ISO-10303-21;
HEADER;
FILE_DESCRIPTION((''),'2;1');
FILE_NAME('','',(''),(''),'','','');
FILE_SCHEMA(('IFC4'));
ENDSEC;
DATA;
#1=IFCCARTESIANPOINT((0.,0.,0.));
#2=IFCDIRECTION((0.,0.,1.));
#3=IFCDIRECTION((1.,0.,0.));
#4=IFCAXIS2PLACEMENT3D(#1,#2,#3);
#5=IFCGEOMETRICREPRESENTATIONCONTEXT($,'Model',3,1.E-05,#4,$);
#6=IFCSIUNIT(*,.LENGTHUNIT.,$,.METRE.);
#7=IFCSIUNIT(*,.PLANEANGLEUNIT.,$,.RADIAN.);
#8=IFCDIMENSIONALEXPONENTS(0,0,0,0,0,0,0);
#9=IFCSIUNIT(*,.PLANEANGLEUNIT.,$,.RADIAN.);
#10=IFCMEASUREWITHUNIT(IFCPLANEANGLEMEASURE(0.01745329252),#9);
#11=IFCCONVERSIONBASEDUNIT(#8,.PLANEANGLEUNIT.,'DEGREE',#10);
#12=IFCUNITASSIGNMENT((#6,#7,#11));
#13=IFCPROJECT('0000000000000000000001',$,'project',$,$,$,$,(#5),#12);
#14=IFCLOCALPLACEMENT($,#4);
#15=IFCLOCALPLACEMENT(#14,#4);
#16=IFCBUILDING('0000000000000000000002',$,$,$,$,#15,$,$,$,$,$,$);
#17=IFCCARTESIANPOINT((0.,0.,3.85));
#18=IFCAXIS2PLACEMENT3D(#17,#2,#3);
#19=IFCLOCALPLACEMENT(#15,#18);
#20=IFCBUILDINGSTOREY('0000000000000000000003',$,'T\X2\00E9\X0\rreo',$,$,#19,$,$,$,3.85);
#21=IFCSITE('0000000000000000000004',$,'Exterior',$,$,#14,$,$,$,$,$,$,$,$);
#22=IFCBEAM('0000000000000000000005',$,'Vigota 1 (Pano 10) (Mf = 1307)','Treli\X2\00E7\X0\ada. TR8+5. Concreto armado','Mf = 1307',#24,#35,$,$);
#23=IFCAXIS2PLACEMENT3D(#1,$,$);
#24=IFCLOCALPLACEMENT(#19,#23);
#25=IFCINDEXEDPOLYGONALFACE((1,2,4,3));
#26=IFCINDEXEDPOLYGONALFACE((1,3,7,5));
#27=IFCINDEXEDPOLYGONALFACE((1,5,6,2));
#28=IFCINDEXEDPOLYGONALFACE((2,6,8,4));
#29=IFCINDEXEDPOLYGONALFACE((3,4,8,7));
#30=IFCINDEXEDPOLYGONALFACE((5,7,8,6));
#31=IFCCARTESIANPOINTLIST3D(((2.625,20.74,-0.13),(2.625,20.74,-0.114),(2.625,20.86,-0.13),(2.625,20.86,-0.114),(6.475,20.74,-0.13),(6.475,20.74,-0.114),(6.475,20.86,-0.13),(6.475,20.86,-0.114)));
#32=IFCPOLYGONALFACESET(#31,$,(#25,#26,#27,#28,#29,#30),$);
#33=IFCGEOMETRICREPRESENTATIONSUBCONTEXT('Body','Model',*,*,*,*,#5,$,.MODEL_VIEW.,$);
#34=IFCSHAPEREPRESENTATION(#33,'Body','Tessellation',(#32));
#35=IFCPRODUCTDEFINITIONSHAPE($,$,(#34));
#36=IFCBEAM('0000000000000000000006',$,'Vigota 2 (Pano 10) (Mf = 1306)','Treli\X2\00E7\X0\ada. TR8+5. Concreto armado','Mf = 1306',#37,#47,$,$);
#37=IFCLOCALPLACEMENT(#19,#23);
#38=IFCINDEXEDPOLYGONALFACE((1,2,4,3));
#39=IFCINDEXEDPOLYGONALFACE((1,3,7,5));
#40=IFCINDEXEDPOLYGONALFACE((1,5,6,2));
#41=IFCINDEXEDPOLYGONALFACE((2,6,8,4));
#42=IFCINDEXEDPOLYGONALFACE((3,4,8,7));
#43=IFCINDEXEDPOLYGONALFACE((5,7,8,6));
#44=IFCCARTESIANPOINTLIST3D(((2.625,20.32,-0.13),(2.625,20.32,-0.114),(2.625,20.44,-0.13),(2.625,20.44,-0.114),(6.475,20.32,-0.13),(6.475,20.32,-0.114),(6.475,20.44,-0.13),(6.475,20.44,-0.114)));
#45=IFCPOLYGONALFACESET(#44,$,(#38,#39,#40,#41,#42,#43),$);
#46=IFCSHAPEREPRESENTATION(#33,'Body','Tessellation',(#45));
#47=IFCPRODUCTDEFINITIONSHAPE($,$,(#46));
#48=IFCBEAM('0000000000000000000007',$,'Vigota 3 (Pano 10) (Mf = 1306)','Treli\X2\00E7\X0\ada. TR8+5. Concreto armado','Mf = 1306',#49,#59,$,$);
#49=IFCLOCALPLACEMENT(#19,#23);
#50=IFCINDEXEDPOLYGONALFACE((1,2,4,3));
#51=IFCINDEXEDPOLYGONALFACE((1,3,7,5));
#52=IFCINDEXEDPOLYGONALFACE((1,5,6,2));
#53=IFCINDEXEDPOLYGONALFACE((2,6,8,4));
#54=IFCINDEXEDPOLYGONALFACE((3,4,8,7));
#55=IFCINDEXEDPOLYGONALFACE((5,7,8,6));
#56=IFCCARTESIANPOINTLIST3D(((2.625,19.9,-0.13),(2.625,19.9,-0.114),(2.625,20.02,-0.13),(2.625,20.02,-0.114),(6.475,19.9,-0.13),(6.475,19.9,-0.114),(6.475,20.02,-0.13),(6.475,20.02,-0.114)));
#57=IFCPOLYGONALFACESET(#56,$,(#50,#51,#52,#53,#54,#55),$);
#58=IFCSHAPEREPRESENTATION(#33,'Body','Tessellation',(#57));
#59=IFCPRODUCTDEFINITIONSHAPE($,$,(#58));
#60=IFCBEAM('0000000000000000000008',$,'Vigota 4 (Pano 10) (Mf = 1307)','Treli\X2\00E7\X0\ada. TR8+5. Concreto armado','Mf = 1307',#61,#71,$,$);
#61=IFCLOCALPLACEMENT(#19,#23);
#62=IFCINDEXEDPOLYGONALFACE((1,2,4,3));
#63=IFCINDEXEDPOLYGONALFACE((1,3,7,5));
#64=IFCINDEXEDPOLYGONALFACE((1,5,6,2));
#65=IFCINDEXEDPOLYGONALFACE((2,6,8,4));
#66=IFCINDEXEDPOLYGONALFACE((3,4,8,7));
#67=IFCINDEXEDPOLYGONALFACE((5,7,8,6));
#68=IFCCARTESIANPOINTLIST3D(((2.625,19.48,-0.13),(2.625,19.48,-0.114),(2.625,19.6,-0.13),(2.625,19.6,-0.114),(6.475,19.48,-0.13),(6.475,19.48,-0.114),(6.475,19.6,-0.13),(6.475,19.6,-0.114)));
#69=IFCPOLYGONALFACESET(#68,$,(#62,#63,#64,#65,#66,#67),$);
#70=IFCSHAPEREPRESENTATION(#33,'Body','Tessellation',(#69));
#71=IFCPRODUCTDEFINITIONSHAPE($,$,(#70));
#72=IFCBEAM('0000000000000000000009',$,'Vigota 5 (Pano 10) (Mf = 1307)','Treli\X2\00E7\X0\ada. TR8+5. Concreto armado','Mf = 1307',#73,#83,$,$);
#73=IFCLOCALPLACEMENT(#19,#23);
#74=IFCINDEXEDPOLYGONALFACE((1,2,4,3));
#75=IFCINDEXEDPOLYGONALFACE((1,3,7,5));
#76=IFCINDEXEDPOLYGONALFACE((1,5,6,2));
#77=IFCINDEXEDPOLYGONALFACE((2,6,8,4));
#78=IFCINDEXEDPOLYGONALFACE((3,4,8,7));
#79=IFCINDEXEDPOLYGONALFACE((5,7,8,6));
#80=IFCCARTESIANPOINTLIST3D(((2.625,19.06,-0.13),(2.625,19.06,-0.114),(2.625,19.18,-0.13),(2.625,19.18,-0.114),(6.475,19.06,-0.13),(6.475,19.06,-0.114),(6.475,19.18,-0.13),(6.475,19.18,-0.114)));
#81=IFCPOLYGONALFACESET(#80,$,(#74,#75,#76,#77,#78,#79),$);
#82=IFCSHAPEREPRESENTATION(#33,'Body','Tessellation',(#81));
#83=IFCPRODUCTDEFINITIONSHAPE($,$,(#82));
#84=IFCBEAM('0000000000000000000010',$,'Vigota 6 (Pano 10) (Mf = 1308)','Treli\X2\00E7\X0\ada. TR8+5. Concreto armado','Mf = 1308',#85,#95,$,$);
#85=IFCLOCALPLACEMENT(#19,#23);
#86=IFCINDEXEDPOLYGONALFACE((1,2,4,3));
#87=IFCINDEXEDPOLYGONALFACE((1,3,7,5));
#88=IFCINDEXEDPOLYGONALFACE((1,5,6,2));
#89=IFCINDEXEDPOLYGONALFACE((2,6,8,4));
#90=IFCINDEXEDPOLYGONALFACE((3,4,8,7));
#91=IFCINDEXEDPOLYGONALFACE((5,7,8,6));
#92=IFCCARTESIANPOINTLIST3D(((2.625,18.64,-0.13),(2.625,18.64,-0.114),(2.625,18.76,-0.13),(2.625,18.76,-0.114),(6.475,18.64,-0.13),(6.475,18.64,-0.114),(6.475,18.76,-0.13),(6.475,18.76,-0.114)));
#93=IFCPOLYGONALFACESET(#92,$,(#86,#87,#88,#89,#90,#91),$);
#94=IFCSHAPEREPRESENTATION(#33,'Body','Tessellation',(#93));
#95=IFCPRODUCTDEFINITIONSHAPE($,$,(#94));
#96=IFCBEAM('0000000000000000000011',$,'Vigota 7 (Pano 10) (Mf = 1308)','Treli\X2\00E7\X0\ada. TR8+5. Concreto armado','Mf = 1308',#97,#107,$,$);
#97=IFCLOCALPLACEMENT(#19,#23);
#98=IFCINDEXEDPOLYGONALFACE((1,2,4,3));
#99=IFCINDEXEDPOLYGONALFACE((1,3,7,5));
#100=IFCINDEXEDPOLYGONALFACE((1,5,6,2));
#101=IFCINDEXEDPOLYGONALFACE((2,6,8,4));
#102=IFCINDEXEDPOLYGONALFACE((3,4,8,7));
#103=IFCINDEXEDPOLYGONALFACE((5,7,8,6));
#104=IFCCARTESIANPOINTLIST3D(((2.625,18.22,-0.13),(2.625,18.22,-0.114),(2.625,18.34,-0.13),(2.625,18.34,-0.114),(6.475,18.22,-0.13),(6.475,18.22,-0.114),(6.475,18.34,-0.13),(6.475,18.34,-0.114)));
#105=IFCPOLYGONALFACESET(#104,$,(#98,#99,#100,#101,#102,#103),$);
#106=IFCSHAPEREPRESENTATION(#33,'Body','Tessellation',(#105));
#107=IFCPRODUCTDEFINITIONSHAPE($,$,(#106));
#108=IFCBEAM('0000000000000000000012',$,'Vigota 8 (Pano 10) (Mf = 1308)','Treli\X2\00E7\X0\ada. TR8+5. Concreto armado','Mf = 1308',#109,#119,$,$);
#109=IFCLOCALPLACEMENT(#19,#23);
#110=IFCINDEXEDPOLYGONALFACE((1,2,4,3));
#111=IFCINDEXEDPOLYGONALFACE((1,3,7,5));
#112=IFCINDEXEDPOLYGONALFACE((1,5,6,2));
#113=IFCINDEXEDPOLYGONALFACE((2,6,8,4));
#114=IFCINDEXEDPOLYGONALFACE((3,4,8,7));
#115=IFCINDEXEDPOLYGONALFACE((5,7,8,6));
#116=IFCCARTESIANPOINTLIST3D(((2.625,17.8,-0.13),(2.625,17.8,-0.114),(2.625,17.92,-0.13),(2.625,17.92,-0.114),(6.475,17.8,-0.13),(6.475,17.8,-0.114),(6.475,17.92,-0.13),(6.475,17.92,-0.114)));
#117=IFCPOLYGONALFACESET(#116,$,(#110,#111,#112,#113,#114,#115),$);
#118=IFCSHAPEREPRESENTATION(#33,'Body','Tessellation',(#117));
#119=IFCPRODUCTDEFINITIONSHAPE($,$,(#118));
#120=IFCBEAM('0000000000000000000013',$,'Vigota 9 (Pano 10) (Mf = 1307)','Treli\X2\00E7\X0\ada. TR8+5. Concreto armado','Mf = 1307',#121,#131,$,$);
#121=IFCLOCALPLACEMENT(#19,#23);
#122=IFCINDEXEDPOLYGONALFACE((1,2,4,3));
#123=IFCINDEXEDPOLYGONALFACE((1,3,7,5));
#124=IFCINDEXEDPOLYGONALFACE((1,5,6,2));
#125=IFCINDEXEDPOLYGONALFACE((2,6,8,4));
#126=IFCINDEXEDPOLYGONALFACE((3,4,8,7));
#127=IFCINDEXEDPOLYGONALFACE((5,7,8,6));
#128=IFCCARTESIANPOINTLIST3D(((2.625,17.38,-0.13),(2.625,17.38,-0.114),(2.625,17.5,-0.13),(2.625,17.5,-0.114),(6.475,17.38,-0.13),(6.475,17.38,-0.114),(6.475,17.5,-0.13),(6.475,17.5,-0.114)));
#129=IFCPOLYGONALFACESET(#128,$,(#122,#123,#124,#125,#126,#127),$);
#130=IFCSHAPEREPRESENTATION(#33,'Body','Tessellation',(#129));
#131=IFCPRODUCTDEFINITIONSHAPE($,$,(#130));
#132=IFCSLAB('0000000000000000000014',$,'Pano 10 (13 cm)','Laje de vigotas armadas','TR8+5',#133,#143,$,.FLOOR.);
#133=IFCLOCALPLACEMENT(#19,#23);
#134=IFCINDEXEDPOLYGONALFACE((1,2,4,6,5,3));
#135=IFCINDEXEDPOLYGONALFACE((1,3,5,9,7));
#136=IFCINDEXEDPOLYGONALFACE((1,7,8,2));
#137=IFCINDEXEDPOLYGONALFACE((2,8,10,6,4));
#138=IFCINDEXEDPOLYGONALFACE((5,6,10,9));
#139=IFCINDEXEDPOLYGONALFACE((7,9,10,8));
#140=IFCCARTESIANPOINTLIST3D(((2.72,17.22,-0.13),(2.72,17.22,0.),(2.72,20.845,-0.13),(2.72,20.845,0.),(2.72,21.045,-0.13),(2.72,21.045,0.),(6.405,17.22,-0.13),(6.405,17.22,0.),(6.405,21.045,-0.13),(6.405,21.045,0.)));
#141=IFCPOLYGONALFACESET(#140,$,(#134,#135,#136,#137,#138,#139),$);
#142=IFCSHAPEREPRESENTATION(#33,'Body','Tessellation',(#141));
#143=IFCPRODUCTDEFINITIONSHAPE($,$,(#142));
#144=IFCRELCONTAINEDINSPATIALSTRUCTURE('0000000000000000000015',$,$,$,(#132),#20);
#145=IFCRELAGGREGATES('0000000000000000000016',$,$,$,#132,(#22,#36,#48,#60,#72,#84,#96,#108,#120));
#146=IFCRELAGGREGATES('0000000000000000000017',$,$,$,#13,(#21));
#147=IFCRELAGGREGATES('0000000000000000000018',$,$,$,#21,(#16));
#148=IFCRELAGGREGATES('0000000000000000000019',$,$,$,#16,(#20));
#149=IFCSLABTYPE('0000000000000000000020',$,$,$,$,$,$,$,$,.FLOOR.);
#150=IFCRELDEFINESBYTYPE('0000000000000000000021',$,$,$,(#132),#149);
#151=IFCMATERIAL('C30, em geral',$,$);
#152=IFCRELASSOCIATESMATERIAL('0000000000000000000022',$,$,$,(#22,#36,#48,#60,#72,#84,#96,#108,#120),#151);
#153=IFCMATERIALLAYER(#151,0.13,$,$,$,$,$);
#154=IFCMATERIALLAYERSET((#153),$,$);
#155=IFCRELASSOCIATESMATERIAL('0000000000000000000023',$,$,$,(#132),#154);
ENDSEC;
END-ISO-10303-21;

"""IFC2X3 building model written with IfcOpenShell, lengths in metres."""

from ifc_helpers import new_model, entity, si_unit, converted_unit, frame, origin_with_axes, place, context, subcontext, project, spatial, polyline, outline, extrude, material, layer, layer_set, layer_usage, type_object, element, aggregate, save


model = new_model("IFC2X3")

# Units and contexts
model_context = context("Model", 3, precision=1e-05, world=origin_with_axes())
body_context = subcontext(model_context, "Body", "Model", "MODEL_VIEW")
ifc_project = project(units=[si_unit("LENGTHUNIT", "METRE"), si_unit("PLANEANGLEUNIT", "RADIAN"), converted_unit("PLANEANGLEUNIT", "DEGREE", entity("IfcPlaneAngleMeasure", 0.01745329252), si_unit("PLANEANGLEUNIT", "RADIAN"), dimensions=[0, 0, 0, 0, 0, 0, 0])], contexts=[model_context])

# Beams
ifc_material = material(Name="C30, em geral")
site_placement = place(None, origin_with_axes())
building_placement = place(site_placement, origin_with_axes())
storey_placement = place(building_placement, frame((0.0, 0.0, 3.85), z_axis=(0.0, 0.0, 1.0), x_axis=(1.0, 0.0, 0.0)))
beam_1_placement = place(storey_placement, frame((2.625, 20.8, -0.122), z_axis=(1.0, 0.0, 0.0), x_axis=(0.0, 1.0, 0.0)))
beam_1 = element("IfcBeam", 1, at=beam_1_placement, material=ifc_material, Name="Vigota 1 (Pano 10) (Mf = 1307)", Description="Treliçada. TR8+5. Concreto armado", ObjectType="Mf = 1307", context=body_context, shape_type="SweptSolid", body=[
    extrude(outline(polyline([(0.06, 0.008), (-0.06, 0.008), (-0.06, -0.008), (0.06, -0.008), (0.06, 0.008)])), origin_with_axes(), (0.0, 0.0, 1.0), 3.85),
])
beam_2_placement = place(storey_placement, frame((2.625, 20.38, -0.122), z_axis=(1.0, 0.0, 0.0), x_axis=(0.0, 1.0, 0.0)))
beam_2 = element("IfcBeam", 2, at=beam_2_placement, material=ifc_material, Name="Vigota 2 (Pano 10) (Mf = 1306)", Description="Treliçada. TR8+5. Concreto armado", ObjectType="Mf = 1306", context=body_context, shape_type="SweptSolid", body=[
    extrude(outline(polyline([(0.06, 0.008), (-0.06, 0.008), (-0.06, -0.008), (0.06, -0.008), (0.06, 0.008)])), origin_with_axes(), (0.0, 0.0, 1.0), 3.85),
])
beam_3_placement = place(storey_placement, frame((2.625, 19.96, -0.122), z_axis=(1.0, 0.0, 0.0), x_axis=(0.0, 1.0, 0.0)))
beam_3 = element("IfcBeam", 3, at=beam_3_placement, material=ifc_material, Name="Vigota 3 (Pano 10) (Mf = 1306)", Description="Treliçada. TR8+5. Concreto armado", ObjectType="Mf = 1306", context=body_context, shape_type="SweptSolid", body=[
    extrude(outline(polyline([(0.06, 0.008), (-0.06, 0.008), (-0.06, -0.008), (0.06, -0.008), (0.06, 0.008)])), origin_with_axes(), (0.0, 0.0, 1.0), 3.85),
])
beam_4_placement = place(storey_placement, frame((2.625, 19.54, -0.122), z_axis=(1.0, 0.0, 0.0), x_axis=(0.0, 1.0, 0.0)))
beam_4 = element("IfcBeam", 4, at=beam_4_placement, material=ifc_material, Name="Vigota 4 (Pano 10) (Mf = 1307)", Description="Treliçada. TR8+5. Concreto armado", ObjectType="Mf = 1307", context=body_context, shape_type="SweptSolid", body=[
    extrude(outline(polyline([(0.06, 0.008), (-0.06, 0.008), (-0.06, -0.008), (0.06, -0.008), (0.06, 0.008)])), origin_with_axes(), (0.0, 0.0, 1.0), 3.85),
])
beam_5_placement = place(storey_placement, frame((2.625, 19.12, -0.122), z_axis=(1.0, 0.0, 0.0), x_axis=(0.0, 1.0, 0.0)))
beam_5 = element("IfcBeam", 5, at=beam_5_placement, material=ifc_material, Name="Vigota 5 (Pano 10) (Mf = 1307)", Description="Treliçada. TR8+5. Concreto armado", ObjectType="Mf = 1307", context=body_context, shape_type="SweptSolid", body=[
    extrude(outline(polyline([(0.06, 0.008), (-0.06, 0.008), (-0.06, -0.008), (0.06, -0.008), (0.06, 0.008)])), origin_with_axes(), (0.0, 0.0, 1.0), 3.85),
])
beam_6_placement = place(storey_placement, frame((2.625, 18.7, -0.122), z_axis=(1.0, 0.0, 0.0), x_axis=(0.0, 1.0, 0.0)))
beam_6 = element("IfcBeam", 6, at=beam_6_placement, material=ifc_material, Name="Vigota 6 (Pano 10) (Mf = 1308)", Description="Treliçada. TR8+5. Concreto armado", ObjectType="Mf = 1308", context=body_context, shape_type="SweptSolid", body=[
    extrude(outline(polyline([(0.06, 0.008), (-0.06, 0.008), (-0.06, -0.008), (0.06, -0.008), (0.06, 0.008)])), origin_with_axes(), (0.0, 0.0, 1.0), 3.85),
])
beam_7_placement = place(storey_placement, frame((2.625, 18.28, -0.122), z_axis=(1.0, 0.0, 0.0), x_axis=(0.0, 1.0, 0.0)))
beam_7 = element("IfcBeam", 7, at=beam_7_placement, material=ifc_material, Name="Vigota 7 (Pano 10) (Mf = 1308)", Description="Treliçada. TR8+5. Concreto armado", ObjectType="Mf = 1308", context=body_context, shape_type="SweptSolid", body=[
    extrude(outline(polyline([(0.06, 0.008), (-0.06, 0.008), (-0.06, -0.008), (0.06, -0.008), (0.06, 0.008)])), origin_with_axes(), (0.0, 0.0, 1.0), 3.85),
])
beam_8_placement = place(storey_placement, frame((2.625, 17.86, -0.122), z_axis=(1.0, 0.0, 0.0), x_axis=(0.0, 1.0, 0.0)))
beam_8 = element("IfcBeam", 8, at=beam_8_placement, material=ifc_material, Name="Vigota 8 (Pano 10) (Mf = 1308)", Description="Treliçada. TR8+5. Concreto armado", ObjectType="Mf = 1308", context=body_context, shape_type="SweptSolid", body=[
    extrude(outline(polyline([(0.06, 0.008), (-0.06, 0.008), (-0.06, -0.008), (0.06, -0.008), (0.06, 0.008)])), origin_with_axes(), (0.0, 0.0, 1.0), 3.85),
])
beam_9_placement = place(storey_placement, frame((2.625, 17.44, -0.122), z_axis=(1.0, 0.0, 0.0), x_axis=(0.0, 1.0, 0.0)))
beam_9 = element("IfcBeam", 9, at=beam_9_placement, material=ifc_material, Name="Vigota 9 (Pano 10) (Mf = 1307)", Description="Treliçada. TR8+5. Concreto armado", ObjectType="Mf = 1307", context=body_context, shape_type="SweptSolid", body=[
    extrude(outline(polyline([(0.06, 0.008), (-0.06, 0.008), (-0.06, -0.008), (0.06, -0.008), (0.06, 0.008)])), origin_with_axes(), (0.0, 0.0, 1.0), 3.85),
])

# Site, building, storey
site = spatial("IfcSite", under=ifc_project, at=site_placement, Name="Exterior")
building = spatial("IfcBuilding", under=site, at=building_placement)
storey = spatial("IfcBuildingStorey", under=building, at=storey_placement, Name="Térreo", Elevation=3.85)

# Slab
slab_type = type_object("IfcSlabType", PredefinedType="FLOOR")
ifc_layer_1 = layer(ifc_material, 0.13)
ifc_layer_set_1 = layer_set([ifc_layer_1])
ifc_layer_usage_1 = layer_usage(ifc_layer_set_1, "AXIS3", "POSITIVE", 0.0)
slab_1_placement = place(storey_placement, frame((0.0, 0.0, -0.13), z_axis=(0.0, 0.0, 1.0), x_axis=(1.0, 0.0, 0.0)))
slab_1 = element("IfcSlab", 10, at=slab_1_placement, inside=storey, type_object=slab_type, material=ifc_layer_usage_1, Name="Pano 10 (13 cm)", Description="Laje de vigotas armadas", ObjectType="TR8+5", PredefinedType="FLOOR", context=body_context, shape_type="SweptSolid", body=[
    extrude(outline(polyline([(2.72, 17.22), (6.405, 17.22), (6.405, 21.045), (2.72, 21.045), (2.72, 20.845), (2.72, 17.22)])), origin_with_axes(), (0.0, 0.0, 1.0), 0.13),
])
aggregate(slab_1, [beam_1, beam_2, beam_3, beam_4, beam_5, beam_6, beam_7, beam_8, beam_9])

save(model, "model.ifc")
